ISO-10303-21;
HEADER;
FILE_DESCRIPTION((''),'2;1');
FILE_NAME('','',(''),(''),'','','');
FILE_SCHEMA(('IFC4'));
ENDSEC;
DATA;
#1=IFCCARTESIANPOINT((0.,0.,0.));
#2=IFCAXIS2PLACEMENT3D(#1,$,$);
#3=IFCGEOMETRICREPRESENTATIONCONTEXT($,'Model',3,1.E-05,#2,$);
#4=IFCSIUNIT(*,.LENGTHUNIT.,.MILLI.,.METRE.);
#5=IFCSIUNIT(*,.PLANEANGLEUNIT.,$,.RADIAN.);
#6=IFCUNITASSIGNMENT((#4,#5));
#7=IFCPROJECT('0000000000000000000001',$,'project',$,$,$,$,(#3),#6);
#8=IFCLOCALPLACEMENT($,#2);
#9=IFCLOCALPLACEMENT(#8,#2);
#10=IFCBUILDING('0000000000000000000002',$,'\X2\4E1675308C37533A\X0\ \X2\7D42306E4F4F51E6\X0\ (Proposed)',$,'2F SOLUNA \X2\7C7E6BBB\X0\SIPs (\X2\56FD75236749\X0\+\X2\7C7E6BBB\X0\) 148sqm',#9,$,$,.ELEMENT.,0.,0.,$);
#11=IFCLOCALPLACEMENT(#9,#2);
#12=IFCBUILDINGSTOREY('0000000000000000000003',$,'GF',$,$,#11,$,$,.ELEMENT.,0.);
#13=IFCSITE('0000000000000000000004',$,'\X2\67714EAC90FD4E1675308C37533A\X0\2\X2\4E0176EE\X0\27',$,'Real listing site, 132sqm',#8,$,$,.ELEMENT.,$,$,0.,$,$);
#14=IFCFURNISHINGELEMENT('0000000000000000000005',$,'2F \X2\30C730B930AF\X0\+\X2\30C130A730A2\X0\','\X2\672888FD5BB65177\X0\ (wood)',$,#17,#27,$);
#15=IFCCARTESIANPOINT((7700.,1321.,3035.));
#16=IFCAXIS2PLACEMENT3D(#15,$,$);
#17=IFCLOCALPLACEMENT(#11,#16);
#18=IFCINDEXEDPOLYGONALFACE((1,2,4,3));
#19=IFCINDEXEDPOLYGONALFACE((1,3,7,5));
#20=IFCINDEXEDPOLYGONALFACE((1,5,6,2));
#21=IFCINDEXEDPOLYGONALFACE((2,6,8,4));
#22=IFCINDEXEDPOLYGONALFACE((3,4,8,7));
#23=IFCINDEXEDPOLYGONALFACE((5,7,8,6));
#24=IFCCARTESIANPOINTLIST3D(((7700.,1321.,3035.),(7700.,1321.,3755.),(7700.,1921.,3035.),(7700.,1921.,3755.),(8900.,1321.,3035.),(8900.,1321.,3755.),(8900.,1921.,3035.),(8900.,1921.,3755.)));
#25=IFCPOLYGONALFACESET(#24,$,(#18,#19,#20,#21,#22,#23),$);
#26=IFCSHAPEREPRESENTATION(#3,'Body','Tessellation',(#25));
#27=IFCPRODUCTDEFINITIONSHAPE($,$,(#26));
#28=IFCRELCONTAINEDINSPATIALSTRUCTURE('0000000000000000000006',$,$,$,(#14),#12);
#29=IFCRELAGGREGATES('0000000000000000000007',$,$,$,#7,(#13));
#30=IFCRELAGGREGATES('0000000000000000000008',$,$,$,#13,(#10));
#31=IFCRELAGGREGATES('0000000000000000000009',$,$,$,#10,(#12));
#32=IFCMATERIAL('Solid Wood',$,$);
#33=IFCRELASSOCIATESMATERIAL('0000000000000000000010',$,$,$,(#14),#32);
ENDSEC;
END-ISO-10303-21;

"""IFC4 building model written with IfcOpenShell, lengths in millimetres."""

from ifc_helpers import new_model, si_unit, frame, frame_2d, origin, place, context, project, spatial, rectangle, extrude, material, element, save


model = new_model("IFC4")

# Units and contexts
model_context = context("Model", 3, precision=1e-05, world=origin())
ifc_project = project(units=[si_unit("LENGTHUNIT", "METRE", prefix="MILLI"), si_unit("PLANEANGLEUNIT", "RADIAN")], contexts=[model_context])

# Site, building, storey
site_placement = place(None, origin())
site = spatial("IfcSite", under=ifc_project, at=site_placement, Name="東京都世田谷区2丁目27", ObjectType="Real listing site, 132sqm", CompositionType="ELEMENT", RefElevation=0.0)
building_placement = place(site_placement, origin())
building = spatial("IfcBuilding", under=site, at=building_placement, Name="世田谷区 終の住処 (Proposed)", ObjectType="2F SOLUNA 籾殻SIPs (国産杉+籾殻) 148sqm", CompositionType="ELEMENT", ElevationOfRefHeight=0.0, ElevationOfTerrain=0.0)
storey_placement = place(building_placement, origin())
storey = spatial("IfcBuildingStorey", under=building, at=storey_placement, Name="GF", CompositionType="ELEMENT", Elevation=0.0)

# Shared definitions
ifc_material_1 = material(Name="Solid Wood")

# Furnishing element
furnishing_1_placement = place(storey_placement, frame((7700.0, 1321.0, 3035.0)))
element("IfcFurnishingElement", 1, at=furnishing_1_placement, inside=storey, material=ifc_material_1, Name="2F デスク+チェア", Description="木製家具 (wood)", context=model_context, shape_type="SweptSolid", body=[
    extrude(rectangle(XDim=1200.0, YDim=600.0, at=frame_2d((600.0, 300.0))), frame((7700.0, 1321.0, 3035.0)), (0.0, 0.0, 1.0), 720.0),
])

save(model, "model.ifc")
